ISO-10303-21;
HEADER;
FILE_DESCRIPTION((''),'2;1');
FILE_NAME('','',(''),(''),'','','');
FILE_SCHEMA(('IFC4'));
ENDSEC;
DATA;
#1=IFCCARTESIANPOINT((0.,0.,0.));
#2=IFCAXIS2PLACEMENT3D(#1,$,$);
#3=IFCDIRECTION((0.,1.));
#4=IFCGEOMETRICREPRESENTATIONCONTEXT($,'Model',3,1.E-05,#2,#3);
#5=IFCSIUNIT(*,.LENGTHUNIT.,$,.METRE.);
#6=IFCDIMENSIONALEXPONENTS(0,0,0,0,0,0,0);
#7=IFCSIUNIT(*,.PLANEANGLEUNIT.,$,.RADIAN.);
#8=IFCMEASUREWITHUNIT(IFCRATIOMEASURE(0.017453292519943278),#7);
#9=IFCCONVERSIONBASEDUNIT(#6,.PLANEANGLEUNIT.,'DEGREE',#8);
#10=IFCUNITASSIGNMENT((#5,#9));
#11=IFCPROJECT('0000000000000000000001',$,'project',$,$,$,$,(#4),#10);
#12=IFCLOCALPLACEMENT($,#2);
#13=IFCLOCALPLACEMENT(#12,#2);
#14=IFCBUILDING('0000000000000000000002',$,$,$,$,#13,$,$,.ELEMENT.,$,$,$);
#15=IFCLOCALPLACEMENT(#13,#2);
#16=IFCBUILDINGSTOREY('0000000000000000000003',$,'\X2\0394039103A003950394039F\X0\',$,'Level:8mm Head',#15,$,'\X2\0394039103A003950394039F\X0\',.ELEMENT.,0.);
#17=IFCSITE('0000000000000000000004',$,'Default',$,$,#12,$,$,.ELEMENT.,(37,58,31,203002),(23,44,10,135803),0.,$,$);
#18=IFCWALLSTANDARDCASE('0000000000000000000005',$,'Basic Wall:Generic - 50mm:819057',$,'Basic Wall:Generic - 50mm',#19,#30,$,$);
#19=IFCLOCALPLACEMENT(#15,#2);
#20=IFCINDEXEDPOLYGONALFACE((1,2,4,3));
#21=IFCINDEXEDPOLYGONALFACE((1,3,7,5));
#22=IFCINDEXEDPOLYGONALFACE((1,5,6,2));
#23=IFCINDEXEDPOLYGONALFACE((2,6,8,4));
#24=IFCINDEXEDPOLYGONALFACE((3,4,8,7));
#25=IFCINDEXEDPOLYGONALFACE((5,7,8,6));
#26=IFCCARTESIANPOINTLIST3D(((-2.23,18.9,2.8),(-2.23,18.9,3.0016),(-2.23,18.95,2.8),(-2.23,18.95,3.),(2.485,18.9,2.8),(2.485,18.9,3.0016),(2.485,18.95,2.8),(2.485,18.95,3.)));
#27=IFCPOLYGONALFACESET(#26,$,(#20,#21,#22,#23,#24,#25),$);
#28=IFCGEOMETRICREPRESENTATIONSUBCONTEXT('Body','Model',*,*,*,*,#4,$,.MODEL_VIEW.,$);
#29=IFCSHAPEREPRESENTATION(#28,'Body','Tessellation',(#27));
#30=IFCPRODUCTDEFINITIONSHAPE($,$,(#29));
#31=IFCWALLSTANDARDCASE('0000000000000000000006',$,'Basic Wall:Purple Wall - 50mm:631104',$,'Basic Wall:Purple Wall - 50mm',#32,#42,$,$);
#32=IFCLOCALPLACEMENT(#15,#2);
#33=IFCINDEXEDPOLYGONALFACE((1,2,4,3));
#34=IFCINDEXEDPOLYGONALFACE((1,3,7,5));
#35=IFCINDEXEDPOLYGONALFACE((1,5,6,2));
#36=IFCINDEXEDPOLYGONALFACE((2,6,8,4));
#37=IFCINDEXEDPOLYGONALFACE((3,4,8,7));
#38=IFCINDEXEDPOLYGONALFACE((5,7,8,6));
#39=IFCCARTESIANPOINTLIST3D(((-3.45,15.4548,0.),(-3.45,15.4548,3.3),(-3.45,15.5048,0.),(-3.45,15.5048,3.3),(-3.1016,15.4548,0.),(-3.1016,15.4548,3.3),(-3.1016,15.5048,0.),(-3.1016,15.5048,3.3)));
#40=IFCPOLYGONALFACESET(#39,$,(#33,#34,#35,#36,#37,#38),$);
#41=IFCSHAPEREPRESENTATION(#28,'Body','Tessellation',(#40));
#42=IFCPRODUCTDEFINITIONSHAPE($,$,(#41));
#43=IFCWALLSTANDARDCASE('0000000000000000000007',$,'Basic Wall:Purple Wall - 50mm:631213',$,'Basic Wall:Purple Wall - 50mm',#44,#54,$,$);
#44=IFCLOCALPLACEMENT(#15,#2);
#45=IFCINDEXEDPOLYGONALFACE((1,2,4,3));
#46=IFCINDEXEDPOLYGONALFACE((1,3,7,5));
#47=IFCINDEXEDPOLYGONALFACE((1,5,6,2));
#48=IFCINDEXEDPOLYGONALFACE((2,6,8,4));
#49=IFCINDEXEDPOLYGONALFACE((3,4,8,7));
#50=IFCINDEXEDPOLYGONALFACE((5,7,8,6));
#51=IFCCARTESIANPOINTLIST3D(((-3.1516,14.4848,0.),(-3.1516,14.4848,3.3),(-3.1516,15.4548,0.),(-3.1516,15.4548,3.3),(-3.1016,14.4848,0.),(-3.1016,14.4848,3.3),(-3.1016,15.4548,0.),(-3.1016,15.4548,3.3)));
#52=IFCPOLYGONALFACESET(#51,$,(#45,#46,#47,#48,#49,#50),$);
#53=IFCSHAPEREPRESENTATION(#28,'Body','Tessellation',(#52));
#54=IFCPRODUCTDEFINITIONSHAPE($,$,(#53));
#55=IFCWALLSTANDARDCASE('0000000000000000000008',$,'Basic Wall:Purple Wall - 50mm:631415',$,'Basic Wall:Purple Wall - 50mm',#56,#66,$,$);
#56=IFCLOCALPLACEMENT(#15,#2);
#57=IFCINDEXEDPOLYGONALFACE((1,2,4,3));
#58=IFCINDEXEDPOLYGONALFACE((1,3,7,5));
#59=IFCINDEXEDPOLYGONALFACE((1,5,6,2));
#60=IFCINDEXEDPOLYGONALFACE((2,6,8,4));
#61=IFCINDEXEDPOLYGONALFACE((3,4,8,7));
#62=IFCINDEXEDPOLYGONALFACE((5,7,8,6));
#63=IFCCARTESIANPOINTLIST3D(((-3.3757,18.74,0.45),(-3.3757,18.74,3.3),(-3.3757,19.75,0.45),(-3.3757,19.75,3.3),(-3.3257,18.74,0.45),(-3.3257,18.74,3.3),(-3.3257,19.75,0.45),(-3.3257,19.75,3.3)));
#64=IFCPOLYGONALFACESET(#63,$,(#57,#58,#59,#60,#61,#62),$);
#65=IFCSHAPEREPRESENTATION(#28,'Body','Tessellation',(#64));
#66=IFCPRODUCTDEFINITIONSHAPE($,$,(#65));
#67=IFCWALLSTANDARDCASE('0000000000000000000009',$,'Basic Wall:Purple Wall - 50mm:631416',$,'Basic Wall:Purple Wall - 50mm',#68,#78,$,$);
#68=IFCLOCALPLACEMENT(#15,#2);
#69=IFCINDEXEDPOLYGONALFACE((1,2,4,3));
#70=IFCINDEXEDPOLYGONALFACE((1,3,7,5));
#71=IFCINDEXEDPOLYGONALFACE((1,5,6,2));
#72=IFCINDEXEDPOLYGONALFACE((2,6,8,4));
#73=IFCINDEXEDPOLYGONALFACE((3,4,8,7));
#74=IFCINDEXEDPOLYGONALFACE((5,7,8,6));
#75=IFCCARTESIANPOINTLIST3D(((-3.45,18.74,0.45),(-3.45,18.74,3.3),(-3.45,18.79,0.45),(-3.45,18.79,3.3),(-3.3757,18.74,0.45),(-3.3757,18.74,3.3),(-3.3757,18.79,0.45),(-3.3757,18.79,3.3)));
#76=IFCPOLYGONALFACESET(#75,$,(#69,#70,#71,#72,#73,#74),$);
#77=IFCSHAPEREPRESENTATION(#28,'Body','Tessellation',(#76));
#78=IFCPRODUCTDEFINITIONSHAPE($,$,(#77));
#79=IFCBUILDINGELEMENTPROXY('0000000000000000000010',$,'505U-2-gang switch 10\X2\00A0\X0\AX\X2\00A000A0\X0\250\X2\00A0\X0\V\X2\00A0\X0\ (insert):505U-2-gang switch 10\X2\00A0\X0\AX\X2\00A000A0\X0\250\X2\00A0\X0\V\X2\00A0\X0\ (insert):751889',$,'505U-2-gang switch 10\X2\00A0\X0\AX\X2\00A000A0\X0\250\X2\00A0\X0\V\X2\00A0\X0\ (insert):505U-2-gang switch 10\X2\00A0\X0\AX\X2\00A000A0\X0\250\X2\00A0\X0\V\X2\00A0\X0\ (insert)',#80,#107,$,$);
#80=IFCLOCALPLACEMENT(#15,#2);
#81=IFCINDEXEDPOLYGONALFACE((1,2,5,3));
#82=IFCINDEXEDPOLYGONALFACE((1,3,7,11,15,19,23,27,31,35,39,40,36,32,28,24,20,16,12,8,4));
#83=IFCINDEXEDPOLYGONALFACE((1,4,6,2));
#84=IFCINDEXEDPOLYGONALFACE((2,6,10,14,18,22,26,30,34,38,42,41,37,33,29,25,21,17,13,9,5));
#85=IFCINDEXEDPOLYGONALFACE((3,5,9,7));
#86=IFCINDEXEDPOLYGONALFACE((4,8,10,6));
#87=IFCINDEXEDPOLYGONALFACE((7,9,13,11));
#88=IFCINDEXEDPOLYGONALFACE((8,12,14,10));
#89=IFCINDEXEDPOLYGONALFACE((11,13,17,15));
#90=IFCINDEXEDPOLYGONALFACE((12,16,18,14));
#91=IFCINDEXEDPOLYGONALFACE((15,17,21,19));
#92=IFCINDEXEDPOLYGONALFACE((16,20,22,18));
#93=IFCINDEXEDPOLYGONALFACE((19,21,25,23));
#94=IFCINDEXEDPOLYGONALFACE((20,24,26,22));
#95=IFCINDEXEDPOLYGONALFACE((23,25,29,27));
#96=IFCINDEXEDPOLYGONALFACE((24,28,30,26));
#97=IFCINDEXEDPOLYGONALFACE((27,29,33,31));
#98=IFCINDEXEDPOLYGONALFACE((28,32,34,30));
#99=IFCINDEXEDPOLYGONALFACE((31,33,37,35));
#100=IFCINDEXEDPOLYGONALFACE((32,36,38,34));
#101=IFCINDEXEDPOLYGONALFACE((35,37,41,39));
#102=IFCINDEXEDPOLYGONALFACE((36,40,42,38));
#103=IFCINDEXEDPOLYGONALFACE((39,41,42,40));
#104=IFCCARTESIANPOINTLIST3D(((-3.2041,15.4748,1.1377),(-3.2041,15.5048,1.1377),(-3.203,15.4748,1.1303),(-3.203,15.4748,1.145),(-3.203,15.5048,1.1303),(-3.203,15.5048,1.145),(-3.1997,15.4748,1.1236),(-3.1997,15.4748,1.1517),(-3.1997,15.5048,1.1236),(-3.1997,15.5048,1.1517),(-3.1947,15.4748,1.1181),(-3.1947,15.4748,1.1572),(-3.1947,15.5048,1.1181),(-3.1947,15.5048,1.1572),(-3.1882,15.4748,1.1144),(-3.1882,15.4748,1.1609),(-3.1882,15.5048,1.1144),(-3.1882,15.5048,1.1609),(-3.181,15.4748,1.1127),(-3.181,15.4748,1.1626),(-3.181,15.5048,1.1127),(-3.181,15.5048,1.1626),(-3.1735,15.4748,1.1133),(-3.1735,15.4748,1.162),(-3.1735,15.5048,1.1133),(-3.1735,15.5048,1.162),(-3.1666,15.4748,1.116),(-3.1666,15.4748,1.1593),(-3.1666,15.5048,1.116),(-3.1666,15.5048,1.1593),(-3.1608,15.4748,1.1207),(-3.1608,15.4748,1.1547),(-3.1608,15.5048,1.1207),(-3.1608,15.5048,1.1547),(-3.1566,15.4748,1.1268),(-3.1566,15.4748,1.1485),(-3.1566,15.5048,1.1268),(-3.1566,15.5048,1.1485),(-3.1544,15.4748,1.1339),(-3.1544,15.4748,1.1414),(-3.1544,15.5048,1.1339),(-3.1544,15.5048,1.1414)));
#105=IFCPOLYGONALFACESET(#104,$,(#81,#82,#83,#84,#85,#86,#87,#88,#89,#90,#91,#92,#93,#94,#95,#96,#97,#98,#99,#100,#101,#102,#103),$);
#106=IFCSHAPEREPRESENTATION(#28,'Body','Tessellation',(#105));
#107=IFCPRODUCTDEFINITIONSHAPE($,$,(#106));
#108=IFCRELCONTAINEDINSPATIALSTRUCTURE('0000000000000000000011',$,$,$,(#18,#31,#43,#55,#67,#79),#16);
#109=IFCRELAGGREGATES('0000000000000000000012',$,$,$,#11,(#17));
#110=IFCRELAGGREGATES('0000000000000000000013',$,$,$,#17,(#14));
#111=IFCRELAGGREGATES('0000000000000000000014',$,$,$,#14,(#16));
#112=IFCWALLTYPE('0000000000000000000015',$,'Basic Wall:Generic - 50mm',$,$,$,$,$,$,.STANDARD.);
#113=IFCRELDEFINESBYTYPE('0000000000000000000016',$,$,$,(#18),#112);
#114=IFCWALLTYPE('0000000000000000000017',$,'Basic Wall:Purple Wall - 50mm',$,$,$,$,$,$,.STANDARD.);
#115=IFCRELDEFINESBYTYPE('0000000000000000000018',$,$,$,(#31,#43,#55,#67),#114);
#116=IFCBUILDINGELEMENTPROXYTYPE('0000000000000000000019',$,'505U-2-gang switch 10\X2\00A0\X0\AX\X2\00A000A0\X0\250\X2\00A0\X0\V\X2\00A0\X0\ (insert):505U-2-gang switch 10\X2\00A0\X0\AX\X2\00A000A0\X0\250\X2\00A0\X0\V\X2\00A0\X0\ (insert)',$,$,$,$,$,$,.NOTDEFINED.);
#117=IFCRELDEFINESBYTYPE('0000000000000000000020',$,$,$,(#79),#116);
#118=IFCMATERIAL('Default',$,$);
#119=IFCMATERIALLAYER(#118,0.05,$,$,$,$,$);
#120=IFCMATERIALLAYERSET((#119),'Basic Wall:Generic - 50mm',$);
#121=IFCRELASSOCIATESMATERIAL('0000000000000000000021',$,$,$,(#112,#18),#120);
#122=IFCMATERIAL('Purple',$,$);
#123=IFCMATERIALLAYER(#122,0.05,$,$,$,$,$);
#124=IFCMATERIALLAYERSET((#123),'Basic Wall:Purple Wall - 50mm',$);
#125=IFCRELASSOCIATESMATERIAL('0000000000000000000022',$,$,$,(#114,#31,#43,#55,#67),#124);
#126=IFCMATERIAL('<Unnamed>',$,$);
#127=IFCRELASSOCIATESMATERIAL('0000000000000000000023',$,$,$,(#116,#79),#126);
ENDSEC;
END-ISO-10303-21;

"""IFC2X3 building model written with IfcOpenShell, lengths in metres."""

from ifc_helpers import new_model, entity, si_unit, converted_unit, direction, frame, frame_2d, origin, place, context, subcontext, project, spatial, polyline, rectangle, circle, extrude, clip, bounded_halfspace, source, transform, mapped, material, layer, layer_set, layer_usage, type_object, type_shapes, element, save


model = new_model("IFC2X3")

# Units and contexts
model_context = context("Model", 3, precision=1e-05, world=origin(), true_north=direction((0.0, 1.0)))
body_context = subcontext(model_context, "Body", "Model", "MODEL_VIEW")
ifc_project = project(units=[si_unit("LENGTHUNIT", "METRE"), converted_unit("PLANEANGLEUNIT", "DEGREE", entity("IfcRatioMeasure", 0.017453292519943278), si_unit("PLANEANGLEUNIT", "RADIAN"), dimensions=[0, 0, 0, 0, 0, 0, 0])], contexts=[model_context])

# Site, building, storey
site_placement = place(None, origin())
site = spatial("IfcSite", under=ifc_project, at=site_placement, Name="Default", CompositionType="ELEMENT", RefLatitude=(37, 58, 31, 203002), RefLongitude=(23, 44, 10, 135803), RefElevation=0.0)
building_placement = place(site_placement, origin())
building = spatial("IfcBuilding", under=site, at=building_placement, CompositionType="ELEMENT")
storey_placement = place(building_placement, origin())
storey = spatial("IfcBuildingStorey", under=building, at=storey_placement, Name="ΔΑΠΕΔΟ", ObjectType="Level:8mm Head", LongName="ΔΑΠΕΔΟ", CompositionType="ELEMENT", Elevation=0.0)

# Shared definitions
ifc_material_1 = material(Name="Default")
ifc_layer_1 = layer(ifc_material_1, 0.05)
ifc_layer_set_1 = layer_set([ifc_layer_1], Name="Basic Wall:Generic - 50mm")
ifc_layer_usage_1 = layer_usage(ifc_layer_set_1, "AXIS2", "NEGATIVE", 0.025)
wall_type_1 = type_object("IfcWallType", Name="Basic Wall:Generic - 50mm", PredefinedType="STANDARD", material=ifc_layer_set_1)

# Walls
wall_1_placement = place(storey_placement, frame((-2.23, 18.925, 2.8)))
element("IfcWallStandardCase", 1, at=wall_1_placement, inside=storey, type_object=wall_type_1, material=ifc_layer_usage_1, Name="Basic Wall:Generic - 50mm:819057", ObjectType="Basic Wall:Generic - 50mm", context=body_context, shape_type="Clipping", body=[
    clip(extrude(rectangle(XDim=4.715, YDim=0.05, at=frame_2d((2.3575, 0.0), x_axis=(-1.0, 0.0))), origin(), (0.0, 0.0, 1.0), 0.2016), bounded_halfspace(frame((0.0, -0.025, 0.2016), z_axis=(0.0, -0.032414, -0.999475), x_axis=(0.0, 0.999475, -0.032414)), True, frame((0.0, -0.025, 0.2016)), polyline([(0.0, 0.0), (4.715, 0.0), (4.715, 0.05), (0.0, 0.05), (0.0, 0.0)]))),
])
ifc_material_2 = material(Name="Purple")
ifc_layer_2 = layer(ifc_material_2, 0.05)
ifc_layer_set_2 = layer_set([ifc_layer_2], Name="Basic Wall:Purple Wall - 50mm")
ifc_layer_usage_2 = layer_usage(ifc_layer_set_2, "AXIS2", "NEGATIVE", 0.025)
wall_type_2 = type_object("IfcWallType", Name="Basic Wall:Purple Wall - 50mm", PredefinedType="STANDARD", material=ifc_layer_set_2)
wall_2_placement = place(storey_placement, frame((-3.45, 15.4798, 0.0)))
element("IfcWallStandardCase", 2, at=wall_2_placement, inside=storey, type_object=wall_type_2, material=ifc_layer_usage_2, Name="Basic Wall:Purple Wall - 50mm:631104", ObjectType="Basic Wall:Purple Wall - 50mm", context=body_context, shape_type="SweptSolid", body=[
    extrude(rectangle(XDim=0.3484, YDim=0.05, at=frame_2d((0.1742, 0.0), x_axis=(-1.0, 0.0))), origin(), (0.0, 0.0, 1.0), 3.3),
])
wall_3_placement = place(storey_placement, frame((-3.1266, 15.4548, 0.0), z_axis=(0.0, 0.0, 1.0), x_axis=(0.0, -1.0, 0.0)))
element("IfcWallStandardCase", 3, at=wall_3_placement, inside=storey, type_object=wall_type_2, material=ifc_layer_usage_2, Name="Basic Wall:Purple Wall - 50mm:631213", ObjectType="Basic Wall:Purple Wall - 50mm", context=body_context, shape_type="Clipping", body=[
    clip(extrude(rectangle(XDim=0.97, YDim=0.05, at=frame_2d((0.485, 0.0), x_axis=(-1.0, 0.0))), origin(), (0.0, 0.0, 1.0), 3.3), bounded_halfspace(frame((0.0, -0.025, 0.0), z_axis=(1.0, 0.0, 0.0), x_axis=(0.0, 1.0, 0.0)), True, frame((0.0, -0.025, 0.0), z_axis=(1.0, 0.0, 0.0), x_axis=(0.0, 1.0, 0.0)), polyline([(0.0, 0.0), (0.05, 0.0), (0.05, 3.3), (0.0, 3.3), (0.0, 0.6508), (0.0, 0.6008), (0.0, 0.0)]))),
])
wall_4_placement = place(storey_placement, frame((-3.3507, 19.75, 0.45), z_axis=(0.0, 0.0, 1.0), x_axis=(0.0, -1.0, 0.0)))
element("IfcWallStandardCase", 4, at=wall_4_placement, inside=storey, type_object=wall_type_2, material=ifc_layer_usage_2, Name="Basic Wall:Purple Wall - 50mm:631415", ObjectType="Basic Wall:Purple Wall - 50mm", context=body_context, shape_type="SweptSolid", body=[
    extrude(rectangle(XDim=1.01, YDim=0.05, at=frame_2d((0.505, 0.0), x_axis=(-1.0, 0.0))), origin(), (0.0, 0.0, 1.0), 2.85),
])
wall_5_placement = place(storey_placement, frame((-3.3757, 18.765, 0.45), z_axis=(0.0, 0.0, 1.0), x_axis=(-1.0, 0.0, 0.0)))
element("IfcWallStandardCase", 5, at=wall_5_placement, inside=storey, type_object=wall_type_2, material=ifc_layer_usage_2, Name="Basic Wall:Purple Wall - 50mm:631416", ObjectType="Basic Wall:Purple Wall - 50mm", context=body_context, shape_type="SweptSolid", body=[
    extrude(rectangle(XDim=0.0743, YDim=0.05, at=frame_2d((0.0372, 0.0), x_axis=(-1.0, 0.0))), origin(), (0.0, 0.0, 1.0), 2.85),
])

# Building element proxy
ifc_material_3 = material(Name="<Unnamed>")
building_element_proxy_type_1 = type_object("IfcBuildingElementProxyType", Name="505U-2-gang switch 10 AX  250 V  (insert):505U-2-gang switch 10 AX  250 V  (insert)", PredefinedType="NOTDEFINED", material=ifc_material_3)
shared_shape_1 = source(origin(), body_context, "Body", "SweptSolid", [
    extrude(circle(Radius=0.025, at=frame_2d((0.0, 0.0), x_axis=(1.0, 0.0))), origin(), (0.0, 0.0, 1.0), 0.03),
])
type_shapes(building_element_proxy_type_1, [shared_shape_1])
proxy_1_placement = place(storey_placement, frame((-3.1791, 15.4748, 1.1377), z_axis=(0.0, 1.0, 0.0), x_axis=(-1.0, 0.0, 0.0)))
element("IfcBuildingElementProxy", 6, at=proxy_1_placement, inside=storey, type_object=building_element_proxy_type_1, material=ifc_material_3, Name="505U-2-gang switch 10 AX  250 V  (insert):505U-2-gang switch 10 AX  250 V  (insert):751889", ObjectType="505U-2-gang switch 10 AX  250 V  (insert):505U-2-gang switch 10 AX  250 V  (insert)", context=body_context, shape_type="MappedRepresentation", body=[
    mapped(shared_shape_1, transform((0.0, 0.0, 0.0), scale=1.0)),
])

save(model, "model.ifc")
